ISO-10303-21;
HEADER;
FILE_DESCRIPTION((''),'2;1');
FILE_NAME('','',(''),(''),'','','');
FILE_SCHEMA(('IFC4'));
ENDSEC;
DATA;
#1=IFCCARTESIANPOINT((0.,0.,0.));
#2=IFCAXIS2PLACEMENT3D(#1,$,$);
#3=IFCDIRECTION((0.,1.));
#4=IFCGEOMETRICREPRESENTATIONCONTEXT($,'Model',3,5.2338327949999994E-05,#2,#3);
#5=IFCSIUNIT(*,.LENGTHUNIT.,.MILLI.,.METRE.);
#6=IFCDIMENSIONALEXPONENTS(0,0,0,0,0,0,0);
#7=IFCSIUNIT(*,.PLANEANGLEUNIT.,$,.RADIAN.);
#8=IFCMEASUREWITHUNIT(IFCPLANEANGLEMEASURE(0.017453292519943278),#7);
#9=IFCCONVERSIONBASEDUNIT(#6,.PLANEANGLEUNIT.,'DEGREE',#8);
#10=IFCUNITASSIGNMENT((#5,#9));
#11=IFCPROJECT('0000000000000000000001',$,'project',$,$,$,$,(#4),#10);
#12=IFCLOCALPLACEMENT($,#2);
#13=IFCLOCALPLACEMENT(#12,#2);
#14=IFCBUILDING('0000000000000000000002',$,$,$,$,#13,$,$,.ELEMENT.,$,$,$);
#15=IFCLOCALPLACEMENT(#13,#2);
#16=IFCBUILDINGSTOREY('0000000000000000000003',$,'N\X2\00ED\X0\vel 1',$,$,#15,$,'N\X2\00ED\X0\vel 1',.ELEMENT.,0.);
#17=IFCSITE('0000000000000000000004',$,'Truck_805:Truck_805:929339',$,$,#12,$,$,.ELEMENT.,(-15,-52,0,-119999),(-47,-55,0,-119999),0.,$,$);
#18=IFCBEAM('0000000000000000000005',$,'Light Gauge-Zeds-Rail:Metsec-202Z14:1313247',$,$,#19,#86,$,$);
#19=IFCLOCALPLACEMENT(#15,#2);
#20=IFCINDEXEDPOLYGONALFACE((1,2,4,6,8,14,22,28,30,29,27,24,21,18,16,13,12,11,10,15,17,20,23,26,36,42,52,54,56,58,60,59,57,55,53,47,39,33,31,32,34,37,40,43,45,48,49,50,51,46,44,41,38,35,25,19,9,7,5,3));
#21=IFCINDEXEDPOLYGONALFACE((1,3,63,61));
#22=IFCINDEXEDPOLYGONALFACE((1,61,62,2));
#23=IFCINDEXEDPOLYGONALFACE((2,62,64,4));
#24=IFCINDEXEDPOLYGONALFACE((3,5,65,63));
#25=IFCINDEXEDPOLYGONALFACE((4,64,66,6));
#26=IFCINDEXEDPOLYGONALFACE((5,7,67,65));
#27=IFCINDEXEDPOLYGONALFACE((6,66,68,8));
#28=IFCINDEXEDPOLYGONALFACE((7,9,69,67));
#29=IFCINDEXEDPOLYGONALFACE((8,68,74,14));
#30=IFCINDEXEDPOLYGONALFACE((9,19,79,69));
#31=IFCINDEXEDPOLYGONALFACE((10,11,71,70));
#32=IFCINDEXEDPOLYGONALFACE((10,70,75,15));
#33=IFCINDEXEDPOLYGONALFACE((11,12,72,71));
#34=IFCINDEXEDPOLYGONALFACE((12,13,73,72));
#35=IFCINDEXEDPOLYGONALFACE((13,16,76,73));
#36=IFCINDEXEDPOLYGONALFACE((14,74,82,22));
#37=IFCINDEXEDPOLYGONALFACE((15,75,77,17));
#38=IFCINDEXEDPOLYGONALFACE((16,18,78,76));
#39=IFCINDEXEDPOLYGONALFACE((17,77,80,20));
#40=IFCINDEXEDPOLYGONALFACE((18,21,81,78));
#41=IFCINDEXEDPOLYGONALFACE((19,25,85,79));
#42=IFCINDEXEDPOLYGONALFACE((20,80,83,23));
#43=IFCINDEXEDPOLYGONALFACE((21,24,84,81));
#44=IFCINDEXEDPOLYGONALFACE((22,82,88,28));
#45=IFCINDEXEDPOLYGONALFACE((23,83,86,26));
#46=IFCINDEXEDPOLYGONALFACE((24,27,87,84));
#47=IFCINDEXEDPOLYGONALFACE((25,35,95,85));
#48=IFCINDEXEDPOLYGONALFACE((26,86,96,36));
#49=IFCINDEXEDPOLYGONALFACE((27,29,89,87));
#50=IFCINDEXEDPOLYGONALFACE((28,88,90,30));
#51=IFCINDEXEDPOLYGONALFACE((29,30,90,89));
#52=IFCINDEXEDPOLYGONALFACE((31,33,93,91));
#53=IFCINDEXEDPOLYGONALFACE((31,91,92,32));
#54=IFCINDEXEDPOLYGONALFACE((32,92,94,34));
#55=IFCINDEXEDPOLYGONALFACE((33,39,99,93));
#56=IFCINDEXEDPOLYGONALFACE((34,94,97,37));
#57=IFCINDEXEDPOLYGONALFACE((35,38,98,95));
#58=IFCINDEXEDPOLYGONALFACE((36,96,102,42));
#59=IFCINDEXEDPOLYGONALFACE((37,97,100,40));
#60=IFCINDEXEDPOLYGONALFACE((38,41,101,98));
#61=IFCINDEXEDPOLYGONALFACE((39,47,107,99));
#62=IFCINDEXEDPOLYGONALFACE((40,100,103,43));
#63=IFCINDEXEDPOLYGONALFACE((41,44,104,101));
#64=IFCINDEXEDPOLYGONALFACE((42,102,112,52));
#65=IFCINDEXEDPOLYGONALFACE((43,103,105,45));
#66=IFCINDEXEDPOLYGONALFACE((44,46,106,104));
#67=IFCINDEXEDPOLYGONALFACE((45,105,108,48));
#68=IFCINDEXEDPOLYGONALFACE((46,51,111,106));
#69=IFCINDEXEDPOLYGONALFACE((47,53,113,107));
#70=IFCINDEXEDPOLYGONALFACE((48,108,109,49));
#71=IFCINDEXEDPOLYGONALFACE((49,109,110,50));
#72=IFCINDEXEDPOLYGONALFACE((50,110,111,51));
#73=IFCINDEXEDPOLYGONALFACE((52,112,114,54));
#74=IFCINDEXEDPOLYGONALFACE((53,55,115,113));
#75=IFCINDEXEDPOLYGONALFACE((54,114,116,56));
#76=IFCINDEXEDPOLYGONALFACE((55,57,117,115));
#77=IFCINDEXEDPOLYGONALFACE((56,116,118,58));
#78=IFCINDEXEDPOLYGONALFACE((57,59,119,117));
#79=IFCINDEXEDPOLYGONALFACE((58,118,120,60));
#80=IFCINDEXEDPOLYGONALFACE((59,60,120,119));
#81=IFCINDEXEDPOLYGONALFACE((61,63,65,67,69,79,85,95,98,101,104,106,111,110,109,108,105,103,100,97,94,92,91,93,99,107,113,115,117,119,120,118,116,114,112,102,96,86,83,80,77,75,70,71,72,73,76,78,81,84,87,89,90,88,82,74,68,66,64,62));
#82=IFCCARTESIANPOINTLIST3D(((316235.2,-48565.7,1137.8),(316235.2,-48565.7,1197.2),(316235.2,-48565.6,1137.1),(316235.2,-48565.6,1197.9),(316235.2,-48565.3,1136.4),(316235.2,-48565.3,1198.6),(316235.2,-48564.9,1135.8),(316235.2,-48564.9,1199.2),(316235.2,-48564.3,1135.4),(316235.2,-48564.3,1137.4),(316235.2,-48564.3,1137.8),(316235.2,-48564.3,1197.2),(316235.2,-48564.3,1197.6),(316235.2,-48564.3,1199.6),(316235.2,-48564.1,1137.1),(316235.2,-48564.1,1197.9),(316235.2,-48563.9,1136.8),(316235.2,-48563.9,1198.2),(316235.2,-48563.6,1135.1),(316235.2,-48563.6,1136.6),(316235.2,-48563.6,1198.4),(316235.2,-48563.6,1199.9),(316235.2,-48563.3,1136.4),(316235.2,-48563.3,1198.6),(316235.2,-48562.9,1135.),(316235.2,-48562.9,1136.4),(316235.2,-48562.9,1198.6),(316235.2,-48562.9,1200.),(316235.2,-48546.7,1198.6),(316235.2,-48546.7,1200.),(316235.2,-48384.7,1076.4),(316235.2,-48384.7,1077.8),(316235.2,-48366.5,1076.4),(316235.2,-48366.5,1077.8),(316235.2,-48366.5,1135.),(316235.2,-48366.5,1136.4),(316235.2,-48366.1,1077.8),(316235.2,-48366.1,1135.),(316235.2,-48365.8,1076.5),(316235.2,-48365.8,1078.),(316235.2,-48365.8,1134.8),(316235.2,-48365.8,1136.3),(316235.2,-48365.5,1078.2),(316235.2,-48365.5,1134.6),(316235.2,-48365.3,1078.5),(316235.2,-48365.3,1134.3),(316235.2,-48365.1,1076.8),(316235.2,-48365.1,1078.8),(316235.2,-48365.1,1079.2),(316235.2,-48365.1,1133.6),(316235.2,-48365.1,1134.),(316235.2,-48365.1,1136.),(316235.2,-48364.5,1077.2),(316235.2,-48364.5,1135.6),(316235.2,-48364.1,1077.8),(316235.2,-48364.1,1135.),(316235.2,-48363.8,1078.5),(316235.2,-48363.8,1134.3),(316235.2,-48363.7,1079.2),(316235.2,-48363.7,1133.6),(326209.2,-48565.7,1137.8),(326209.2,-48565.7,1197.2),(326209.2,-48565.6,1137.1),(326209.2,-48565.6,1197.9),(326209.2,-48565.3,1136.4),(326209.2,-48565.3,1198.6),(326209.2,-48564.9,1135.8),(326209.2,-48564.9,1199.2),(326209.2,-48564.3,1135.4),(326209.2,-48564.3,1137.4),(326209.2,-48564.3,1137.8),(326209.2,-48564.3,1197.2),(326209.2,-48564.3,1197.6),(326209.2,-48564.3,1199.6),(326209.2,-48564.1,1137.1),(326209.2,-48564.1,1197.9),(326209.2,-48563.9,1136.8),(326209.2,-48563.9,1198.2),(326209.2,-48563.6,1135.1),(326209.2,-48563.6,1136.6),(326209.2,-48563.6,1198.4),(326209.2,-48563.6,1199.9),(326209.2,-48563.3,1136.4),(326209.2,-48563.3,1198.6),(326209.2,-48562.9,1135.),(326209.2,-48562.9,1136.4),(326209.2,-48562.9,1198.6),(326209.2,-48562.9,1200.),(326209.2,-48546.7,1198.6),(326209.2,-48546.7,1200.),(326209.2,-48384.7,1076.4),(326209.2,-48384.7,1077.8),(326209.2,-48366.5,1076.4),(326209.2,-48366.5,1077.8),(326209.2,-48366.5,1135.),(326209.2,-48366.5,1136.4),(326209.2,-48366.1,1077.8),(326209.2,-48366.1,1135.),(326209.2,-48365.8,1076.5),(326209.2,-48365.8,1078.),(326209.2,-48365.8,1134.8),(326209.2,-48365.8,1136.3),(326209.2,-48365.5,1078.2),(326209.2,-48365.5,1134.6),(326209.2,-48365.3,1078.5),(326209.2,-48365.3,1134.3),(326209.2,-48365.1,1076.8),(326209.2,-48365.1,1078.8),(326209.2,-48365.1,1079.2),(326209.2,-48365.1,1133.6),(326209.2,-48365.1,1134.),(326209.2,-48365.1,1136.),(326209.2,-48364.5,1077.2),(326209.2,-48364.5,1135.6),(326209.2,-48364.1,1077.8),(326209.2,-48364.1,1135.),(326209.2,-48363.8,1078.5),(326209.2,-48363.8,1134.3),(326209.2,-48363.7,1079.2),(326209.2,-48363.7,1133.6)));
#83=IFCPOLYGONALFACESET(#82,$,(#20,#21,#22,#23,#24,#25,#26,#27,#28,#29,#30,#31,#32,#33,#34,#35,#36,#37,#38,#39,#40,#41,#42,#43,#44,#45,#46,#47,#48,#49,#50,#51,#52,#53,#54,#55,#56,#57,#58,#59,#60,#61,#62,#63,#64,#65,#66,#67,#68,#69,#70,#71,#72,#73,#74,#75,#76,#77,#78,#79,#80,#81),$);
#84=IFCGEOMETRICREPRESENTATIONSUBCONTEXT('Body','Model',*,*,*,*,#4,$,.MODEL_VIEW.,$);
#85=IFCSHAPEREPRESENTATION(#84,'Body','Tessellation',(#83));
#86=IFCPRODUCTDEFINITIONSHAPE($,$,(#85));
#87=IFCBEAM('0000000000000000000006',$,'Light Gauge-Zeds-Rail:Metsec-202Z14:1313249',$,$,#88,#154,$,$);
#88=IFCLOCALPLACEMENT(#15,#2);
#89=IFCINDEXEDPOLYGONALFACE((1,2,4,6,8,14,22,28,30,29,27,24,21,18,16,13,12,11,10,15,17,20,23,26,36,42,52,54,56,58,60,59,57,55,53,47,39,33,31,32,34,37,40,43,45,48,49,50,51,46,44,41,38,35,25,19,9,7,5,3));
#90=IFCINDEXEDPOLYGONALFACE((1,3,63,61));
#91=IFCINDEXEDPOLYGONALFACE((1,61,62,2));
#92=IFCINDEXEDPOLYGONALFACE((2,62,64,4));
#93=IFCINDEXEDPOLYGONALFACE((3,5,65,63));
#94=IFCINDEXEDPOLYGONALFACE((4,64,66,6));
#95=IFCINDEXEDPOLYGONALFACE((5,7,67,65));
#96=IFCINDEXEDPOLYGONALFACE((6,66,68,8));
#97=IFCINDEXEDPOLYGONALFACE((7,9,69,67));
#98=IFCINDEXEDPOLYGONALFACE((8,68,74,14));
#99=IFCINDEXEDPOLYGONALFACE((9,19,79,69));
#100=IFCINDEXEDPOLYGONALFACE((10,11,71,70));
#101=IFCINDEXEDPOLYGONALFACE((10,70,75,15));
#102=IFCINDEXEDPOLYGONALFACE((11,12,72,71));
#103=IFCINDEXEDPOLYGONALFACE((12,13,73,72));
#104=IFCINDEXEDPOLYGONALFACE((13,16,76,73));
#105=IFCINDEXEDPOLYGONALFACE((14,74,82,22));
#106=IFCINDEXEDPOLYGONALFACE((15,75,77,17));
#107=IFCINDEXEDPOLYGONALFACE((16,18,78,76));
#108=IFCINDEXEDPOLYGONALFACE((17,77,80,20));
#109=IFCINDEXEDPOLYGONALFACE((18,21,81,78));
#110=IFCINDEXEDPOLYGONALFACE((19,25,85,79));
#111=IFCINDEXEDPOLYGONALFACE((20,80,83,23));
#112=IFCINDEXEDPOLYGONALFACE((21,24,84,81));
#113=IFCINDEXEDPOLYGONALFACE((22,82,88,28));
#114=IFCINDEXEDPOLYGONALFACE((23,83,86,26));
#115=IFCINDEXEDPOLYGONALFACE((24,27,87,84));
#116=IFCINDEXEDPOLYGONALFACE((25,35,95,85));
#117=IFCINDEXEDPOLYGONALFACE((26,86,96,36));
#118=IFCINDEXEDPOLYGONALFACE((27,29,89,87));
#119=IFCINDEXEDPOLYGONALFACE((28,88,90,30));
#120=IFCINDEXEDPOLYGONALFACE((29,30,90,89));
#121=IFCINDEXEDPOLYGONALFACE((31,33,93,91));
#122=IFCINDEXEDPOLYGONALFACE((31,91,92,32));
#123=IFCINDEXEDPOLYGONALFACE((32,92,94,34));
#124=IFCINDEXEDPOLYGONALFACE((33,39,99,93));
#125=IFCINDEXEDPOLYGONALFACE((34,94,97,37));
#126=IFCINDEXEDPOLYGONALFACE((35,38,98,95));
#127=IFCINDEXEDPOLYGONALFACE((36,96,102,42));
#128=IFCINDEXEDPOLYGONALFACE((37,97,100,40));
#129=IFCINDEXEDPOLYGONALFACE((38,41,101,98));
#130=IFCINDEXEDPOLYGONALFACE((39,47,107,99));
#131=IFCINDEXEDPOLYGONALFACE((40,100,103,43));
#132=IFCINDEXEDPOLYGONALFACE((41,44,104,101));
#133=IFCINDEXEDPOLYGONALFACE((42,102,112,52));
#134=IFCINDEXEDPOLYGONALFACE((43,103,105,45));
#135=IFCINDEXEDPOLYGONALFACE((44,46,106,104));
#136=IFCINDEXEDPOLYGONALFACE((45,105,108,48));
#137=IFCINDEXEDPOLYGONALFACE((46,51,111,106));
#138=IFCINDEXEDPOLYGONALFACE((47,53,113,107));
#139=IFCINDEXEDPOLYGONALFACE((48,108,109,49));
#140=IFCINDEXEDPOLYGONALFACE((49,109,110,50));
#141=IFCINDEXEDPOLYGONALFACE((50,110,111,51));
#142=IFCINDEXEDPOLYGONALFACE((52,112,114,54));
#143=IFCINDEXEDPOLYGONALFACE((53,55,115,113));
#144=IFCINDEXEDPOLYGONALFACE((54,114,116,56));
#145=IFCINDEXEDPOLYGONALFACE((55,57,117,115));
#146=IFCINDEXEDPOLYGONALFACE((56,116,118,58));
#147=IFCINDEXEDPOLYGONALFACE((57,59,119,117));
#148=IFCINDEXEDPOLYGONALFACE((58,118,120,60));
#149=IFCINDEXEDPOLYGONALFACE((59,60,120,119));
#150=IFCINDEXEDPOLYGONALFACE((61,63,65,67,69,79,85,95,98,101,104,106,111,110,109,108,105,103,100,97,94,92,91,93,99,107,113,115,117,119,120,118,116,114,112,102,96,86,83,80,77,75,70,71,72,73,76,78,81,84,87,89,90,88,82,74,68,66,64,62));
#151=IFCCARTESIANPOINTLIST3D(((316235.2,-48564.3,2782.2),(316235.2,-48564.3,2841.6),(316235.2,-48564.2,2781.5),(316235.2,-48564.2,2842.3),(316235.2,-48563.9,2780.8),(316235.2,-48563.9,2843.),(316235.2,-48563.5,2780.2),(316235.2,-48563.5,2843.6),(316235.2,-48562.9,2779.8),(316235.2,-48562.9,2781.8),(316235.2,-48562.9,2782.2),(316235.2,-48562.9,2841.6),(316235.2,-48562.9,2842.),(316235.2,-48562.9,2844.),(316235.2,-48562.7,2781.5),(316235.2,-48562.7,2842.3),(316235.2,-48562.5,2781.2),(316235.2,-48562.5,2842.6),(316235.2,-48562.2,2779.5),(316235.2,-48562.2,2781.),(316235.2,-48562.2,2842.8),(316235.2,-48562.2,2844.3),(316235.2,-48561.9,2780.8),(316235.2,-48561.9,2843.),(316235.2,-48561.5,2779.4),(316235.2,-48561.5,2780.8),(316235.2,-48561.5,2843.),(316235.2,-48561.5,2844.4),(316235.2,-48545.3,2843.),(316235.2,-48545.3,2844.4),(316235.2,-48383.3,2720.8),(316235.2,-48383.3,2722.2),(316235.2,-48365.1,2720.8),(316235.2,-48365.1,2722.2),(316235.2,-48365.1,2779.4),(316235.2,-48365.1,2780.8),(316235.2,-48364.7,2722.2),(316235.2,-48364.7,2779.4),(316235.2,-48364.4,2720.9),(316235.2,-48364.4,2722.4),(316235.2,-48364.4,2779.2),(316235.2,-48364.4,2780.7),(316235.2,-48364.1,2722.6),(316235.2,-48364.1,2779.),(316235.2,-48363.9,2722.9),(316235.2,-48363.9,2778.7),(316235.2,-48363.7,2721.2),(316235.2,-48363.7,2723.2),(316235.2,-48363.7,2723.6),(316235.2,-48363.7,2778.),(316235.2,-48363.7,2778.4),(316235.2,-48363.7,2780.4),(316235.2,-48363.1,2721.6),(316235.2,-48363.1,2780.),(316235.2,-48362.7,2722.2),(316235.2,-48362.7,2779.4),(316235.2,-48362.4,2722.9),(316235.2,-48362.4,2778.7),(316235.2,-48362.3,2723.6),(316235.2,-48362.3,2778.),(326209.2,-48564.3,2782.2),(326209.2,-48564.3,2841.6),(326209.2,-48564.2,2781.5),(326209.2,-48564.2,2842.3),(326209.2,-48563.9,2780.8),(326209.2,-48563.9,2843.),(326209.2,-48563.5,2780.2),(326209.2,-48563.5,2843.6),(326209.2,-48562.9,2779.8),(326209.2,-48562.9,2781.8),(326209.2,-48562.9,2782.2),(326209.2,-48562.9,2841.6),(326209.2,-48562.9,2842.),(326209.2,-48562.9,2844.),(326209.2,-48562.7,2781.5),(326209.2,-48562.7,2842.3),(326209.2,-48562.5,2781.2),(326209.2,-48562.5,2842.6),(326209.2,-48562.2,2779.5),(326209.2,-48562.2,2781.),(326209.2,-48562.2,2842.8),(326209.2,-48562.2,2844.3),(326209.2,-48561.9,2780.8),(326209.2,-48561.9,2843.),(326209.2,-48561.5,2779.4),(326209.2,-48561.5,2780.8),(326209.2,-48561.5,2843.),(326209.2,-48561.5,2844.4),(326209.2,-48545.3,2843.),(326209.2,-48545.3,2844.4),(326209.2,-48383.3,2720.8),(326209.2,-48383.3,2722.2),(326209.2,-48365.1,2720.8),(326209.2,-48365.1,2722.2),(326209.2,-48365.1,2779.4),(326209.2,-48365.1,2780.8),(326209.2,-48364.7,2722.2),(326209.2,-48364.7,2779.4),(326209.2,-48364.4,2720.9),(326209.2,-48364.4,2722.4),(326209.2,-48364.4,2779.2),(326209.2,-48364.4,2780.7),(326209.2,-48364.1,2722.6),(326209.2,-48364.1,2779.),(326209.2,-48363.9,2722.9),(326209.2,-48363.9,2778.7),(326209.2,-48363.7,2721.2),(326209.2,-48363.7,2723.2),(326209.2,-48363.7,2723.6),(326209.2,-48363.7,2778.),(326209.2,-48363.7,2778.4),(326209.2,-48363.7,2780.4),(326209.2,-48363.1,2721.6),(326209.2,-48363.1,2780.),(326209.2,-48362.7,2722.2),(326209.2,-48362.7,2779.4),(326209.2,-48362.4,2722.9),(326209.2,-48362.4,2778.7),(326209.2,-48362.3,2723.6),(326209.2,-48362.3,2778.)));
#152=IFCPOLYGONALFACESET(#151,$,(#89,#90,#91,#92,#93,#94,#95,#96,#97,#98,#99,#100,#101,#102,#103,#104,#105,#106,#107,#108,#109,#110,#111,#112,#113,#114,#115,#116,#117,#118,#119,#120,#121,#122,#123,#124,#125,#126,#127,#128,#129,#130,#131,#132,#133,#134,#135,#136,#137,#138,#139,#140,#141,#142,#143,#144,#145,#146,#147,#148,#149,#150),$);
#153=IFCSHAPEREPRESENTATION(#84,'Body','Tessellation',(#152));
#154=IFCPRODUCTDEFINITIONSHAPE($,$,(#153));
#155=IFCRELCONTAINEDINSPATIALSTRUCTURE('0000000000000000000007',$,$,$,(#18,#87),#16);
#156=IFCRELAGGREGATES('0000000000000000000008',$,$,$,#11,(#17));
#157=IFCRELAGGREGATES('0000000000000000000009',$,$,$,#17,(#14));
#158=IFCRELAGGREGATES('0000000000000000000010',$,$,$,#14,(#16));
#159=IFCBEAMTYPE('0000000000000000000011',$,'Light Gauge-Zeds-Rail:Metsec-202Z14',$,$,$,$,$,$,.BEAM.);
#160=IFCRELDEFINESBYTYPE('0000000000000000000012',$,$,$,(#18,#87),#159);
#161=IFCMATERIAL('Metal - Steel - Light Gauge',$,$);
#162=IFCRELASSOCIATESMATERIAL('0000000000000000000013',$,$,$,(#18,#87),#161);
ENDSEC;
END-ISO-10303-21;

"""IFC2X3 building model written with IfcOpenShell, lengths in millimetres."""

from ifc_helpers import new_model, entity, si_unit, converted_unit, direction, frame, frame_2d, origin, place, context, subcontext, project, spatial, polyline, circle_curve, parameter, trimmed, segment, composite_curve, outline, extrude, material, type_object, element, save


model = new_model("IFC2X3")

# Units and contexts
model_context = context("Model", 3, precision=5.2338327949999994e-05, world=origin(), true_north=direction((0.0, 1.0)))
body_context = subcontext(model_context, "Body", "Model", "MODEL_VIEW")
ifc_project = project(units=[si_unit("LENGTHUNIT", "METRE", prefix="MILLI"), converted_unit("PLANEANGLEUNIT", "DEGREE", entity("IfcPlaneAngleMeasure", 0.017453292519943278), si_unit("PLANEANGLEUNIT", "RADIAN"), dimensions=[0, 0, 0, 0, 0, 0, 0])], contexts=[model_context])

# Site, building, storey
site_placement = place(None, origin())
site = spatial("IfcSite", under=ifc_project, at=site_placement, Name="Truck_805:Truck_805:929339", CompositionType="ELEMENT", RefLatitude=(-15, -52, 0, -119999), RefLongitude=(-47, -55, 0, -119999), RefElevation=0.0)
building_placement = place(site_placement, origin())
building = spatial("IfcBuilding", under=site, at=building_placement, CompositionType="ELEMENT")
storey_placement = place(building_placement, origin())
storey = spatial("IfcBuildingStorey", under=building, at=storey_placement, Name="Nível 1", LongName="Nível 1", CompositionType="ELEMENT", Elevation=0.0)

# Beams
ifc_material_1 = material(Name="Metal - Steel - Light Gauge")
beam_type_1 = type_object("IfcBeamType", Name="Light Gauge-Zeds-Rail:Metsec-202Z14", PredefinedType="BEAM")
beam_1_placement = place(storey_placement, frame((316222.2, -48465.6, 1200.0)))
element("IfcBeam", 1, at=beam_1_placement, inside=storey, type_object=beam_type_1, material=ifc_material_1, Name="Light Gauge-Zeds-Rail:Metsec-202Z14:1313247", context=body_context, shape_type="SweptSolid", body=[
    extrude(outline(composite_curve([segment(polyline([(-60.0, -100.8), (-0.6, -100.8)]), True, "CONTINUOUS"), segment(trimmed(circle_curve(frame_2d((-0.6, -98.0), x_axis=(0.0, -1.0)), 2.8), [parameter(0.0)], [parameter(90.0)], True, "PARAMETER"), True, "CONTINUOUS"), segment(polyline([(2.2, -98.0), (2.2, 98.4)]), True, "CONTINUOUS"), segment(trimmed(circle_curve(frame_2d((3.6, 98.4), x_axis=(-1.0, 0.0)), 1.4), [parameter(270.0)], [parameter(0.0)], True, "PARAMETER"), False, "CONTINUOUS"), segment(polyline([(3.6, 99.8), (58.0, 99.8)]), True, "CONTINUOUS"), segment(trimmed(circle_curve(frame_2d((58.0, 98.4), x_axis=(0.0, 1.0)), 1.4), [parameter(270.0)], [parameter(0.0)], True, "PARAMETER"), False, "CONTINUOUS"), segment(polyline([(59.4, 98.4), (59.4, 80.2)]), True, "CONTINUOUS"), segment(polyline([(59.4, 80.2), (60.8, 80.2)]), True, "CONTINUOUS"), segment(polyline([(60.8, 80.2), (60.8, 98.4)]), True, "CONTINUOUS"), segment(trimmed(circle_curve(frame_2d((58.0, 98.4), x_axis=(1.0, 0.0)), 2.8), [parameter(0.0)], [parameter(90.0)], True, "PARAMETER"), True, "CONTINUOUS"), segment(polyline([(58.0, 101.2), (3.6, 101.2)]), True, "CONTINUOUS"), segment(trimmed(circle_curve(frame_2d((3.6, 98.4), x_axis=(0.0, 1.0)), 2.8), [parameter(0.0)], [parameter(90.0)], True, "PARAMETER"), True, "CONTINUOUS"), segment(polyline([(0.8, 98.4), (0.8, -98.0)]), True, "CONTINUOUS"), segment(trimmed(circle_curve(frame_2d((-0.6, -98.0), x_axis=(1.0, 0.0)), 1.4), [parameter(270.0)], [parameter(0.0)], True, "PARAMETER"), False, "CONTINUOUS"), segment(polyline([(-0.6, -99.4), (-60.0, -99.4)]), True, "CONTINUOUS"), segment(trimmed(circle_curve(frame_2d((-60.0, -98.0), x_axis=(0.0, -1.0)), 1.4), [parameter(270.0)], [parameter(0.0)], True, "PARAMETER"), False, "CONTINUOUS"), segment(polyline([(-61.4, -98.0), (-61.4, -81.8)]), True, "CONTINUOUS"), segment(polyline([(-61.4, -81.8), (-62.8, -81.8)]), True, "CONTINUOUS"), segment(polyline([(-62.8, -81.8), (-62.8, -98.0)]), True, "CONTINUOUS"), segment(trimmed(circle_curve(frame_2d((-60.0, -98.0), x_axis=(-1.0, 0.0)), 2.8), [parameter(0.0)], [parameter(90.0)], True, "PARAMETER"), True, "CONTINUOUS")], self_intersect=False)), frame((13.0, 0.7, -62.8), z_axis=(1.0, 0.0, 0.0), x_axis=(0.0, 0.0, -1.0)), (0.0, 0.0, 1.0), 9974.0),
])
beam_2_placement = place(storey_placement, frame((316222.2, -48464.2, 2844.4)))
element("IfcBeam", 2, at=beam_2_placement, inside=storey, type_object=beam_type_1, material=ifc_material_1, Name="Light Gauge-Zeds-Rail:Metsec-202Z14:1313249", context=body_context, shape_type="SweptSolid", body=[
    extrude(outline(composite_curve([segment(polyline([(-60.0, -100.8), (-0.6, -100.8)]), True, "CONTINUOUS"), segment(trimmed(circle_curve(frame_2d((-0.6, -98.0), x_axis=(0.0, -1.0)), 2.8), [parameter(0.0)], [parameter(90.0)], True, "PARAMETER"), True, "CONTINUOUS"), segment(polyline([(2.2, -98.0), (2.2, 98.4)]), True, "CONTINUOUS"), segment(trimmed(circle_curve(frame_2d((3.6, 98.4), x_axis=(-1.0, 0.0)), 1.4), [parameter(270.0)], [parameter(0.0)], True, "PARAMETER"), False, "CONTINUOUS"), segment(polyline([(3.6, 99.8), (58.0, 99.8)]), True, "CONTINUOUS"), segment(trimmed(circle_curve(frame_2d((58.0, 98.4), x_axis=(0.0, 1.0)), 1.4), [parameter(270.0)], [parameter(0.0)], True, "PARAMETER"), False, "CONTINUOUS"), segment(polyline([(59.4, 98.4), (59.4, 80.2)]), True, "CONTINUOUS"), segment(polyline([(59.4, 80.2), (60.8, 80.2)]), True, "CONTINUOUS"), segment(polyline([(60.8, 80.2), (60.8, 98.4)]), True, "CONTINUOUS"), segment(trimmed(circle_curve(frame_2d((58.0, 98.4), x_axis=(1.0, 0.0)), 2.8), [parameter(0.0)], [parameter(90.0)], True, "PARAMETER"), True, "CONTINUOUS"), segment(polyline([(58.0, 101.2), (3.6, 101.2)]), True, "CONTINUOUS"), segment(trimmed(circle_curve(frame_2d((3.6, 98.4), x_axis=(0.0, 1.0)), 2.8), [parameter(0.0)], [parameter(90.0)], True, "PARAMETER"), True, "CONTINUOUS"), segment(polyline([(0.8, 98.4), (0.8, -98.0)]), True, "CONTINUOUS"), segment(trimmed(circle_curve(frame_2d((-0.6, -98.0), x_axis=(1.0, 0.0)), 1.4), [parameter(270.0)], [parameter(0.0)], True, "PARAMETER"), False, "CONTINUOUS"), segment(polyline([(-0.6, -99.4), (-60.0, -99.4)]), True, "CONTINUOUS"), segment(trimmed(circle_curve(frame_2d((-60.0, -98.0), x_axis=(0.0, -1.0)), 1.4), [parameter(270.0)], [parameter(0.0)], True, "PARAMETER"), False, "CONTINUOUS"), segment(polyline([(-61.4, -98.0), (-61.4, -81.8)]), True, "CONTINUOUS"), segment(polyline([(-61.4, -81.8), (-62.8, -81.8)]), True, "CONTINUOUS"), segment(polyline([(-62.8, -81.8), (-62.8, -98.0)]), True, "CONTINUOUS"), segment(trimmed(circle_curve(frame_2d((-60.0, -98.0), x_axis=(-1.0, 0.0)), 2.8), [parameter(0.0)], [parameter(90.0)], True, "PARAMETER"), True, "CONTINUOUS")], self_intersect=False)), frame((13.0, 0.7, -62.8), z_axis=(1.0, 0.0, 0.0), x_axis=(0.0, 0.0, -1.0)), (0.0, 0.0, 1.0), 9974.0),
])

save(model, "model.ifc")
